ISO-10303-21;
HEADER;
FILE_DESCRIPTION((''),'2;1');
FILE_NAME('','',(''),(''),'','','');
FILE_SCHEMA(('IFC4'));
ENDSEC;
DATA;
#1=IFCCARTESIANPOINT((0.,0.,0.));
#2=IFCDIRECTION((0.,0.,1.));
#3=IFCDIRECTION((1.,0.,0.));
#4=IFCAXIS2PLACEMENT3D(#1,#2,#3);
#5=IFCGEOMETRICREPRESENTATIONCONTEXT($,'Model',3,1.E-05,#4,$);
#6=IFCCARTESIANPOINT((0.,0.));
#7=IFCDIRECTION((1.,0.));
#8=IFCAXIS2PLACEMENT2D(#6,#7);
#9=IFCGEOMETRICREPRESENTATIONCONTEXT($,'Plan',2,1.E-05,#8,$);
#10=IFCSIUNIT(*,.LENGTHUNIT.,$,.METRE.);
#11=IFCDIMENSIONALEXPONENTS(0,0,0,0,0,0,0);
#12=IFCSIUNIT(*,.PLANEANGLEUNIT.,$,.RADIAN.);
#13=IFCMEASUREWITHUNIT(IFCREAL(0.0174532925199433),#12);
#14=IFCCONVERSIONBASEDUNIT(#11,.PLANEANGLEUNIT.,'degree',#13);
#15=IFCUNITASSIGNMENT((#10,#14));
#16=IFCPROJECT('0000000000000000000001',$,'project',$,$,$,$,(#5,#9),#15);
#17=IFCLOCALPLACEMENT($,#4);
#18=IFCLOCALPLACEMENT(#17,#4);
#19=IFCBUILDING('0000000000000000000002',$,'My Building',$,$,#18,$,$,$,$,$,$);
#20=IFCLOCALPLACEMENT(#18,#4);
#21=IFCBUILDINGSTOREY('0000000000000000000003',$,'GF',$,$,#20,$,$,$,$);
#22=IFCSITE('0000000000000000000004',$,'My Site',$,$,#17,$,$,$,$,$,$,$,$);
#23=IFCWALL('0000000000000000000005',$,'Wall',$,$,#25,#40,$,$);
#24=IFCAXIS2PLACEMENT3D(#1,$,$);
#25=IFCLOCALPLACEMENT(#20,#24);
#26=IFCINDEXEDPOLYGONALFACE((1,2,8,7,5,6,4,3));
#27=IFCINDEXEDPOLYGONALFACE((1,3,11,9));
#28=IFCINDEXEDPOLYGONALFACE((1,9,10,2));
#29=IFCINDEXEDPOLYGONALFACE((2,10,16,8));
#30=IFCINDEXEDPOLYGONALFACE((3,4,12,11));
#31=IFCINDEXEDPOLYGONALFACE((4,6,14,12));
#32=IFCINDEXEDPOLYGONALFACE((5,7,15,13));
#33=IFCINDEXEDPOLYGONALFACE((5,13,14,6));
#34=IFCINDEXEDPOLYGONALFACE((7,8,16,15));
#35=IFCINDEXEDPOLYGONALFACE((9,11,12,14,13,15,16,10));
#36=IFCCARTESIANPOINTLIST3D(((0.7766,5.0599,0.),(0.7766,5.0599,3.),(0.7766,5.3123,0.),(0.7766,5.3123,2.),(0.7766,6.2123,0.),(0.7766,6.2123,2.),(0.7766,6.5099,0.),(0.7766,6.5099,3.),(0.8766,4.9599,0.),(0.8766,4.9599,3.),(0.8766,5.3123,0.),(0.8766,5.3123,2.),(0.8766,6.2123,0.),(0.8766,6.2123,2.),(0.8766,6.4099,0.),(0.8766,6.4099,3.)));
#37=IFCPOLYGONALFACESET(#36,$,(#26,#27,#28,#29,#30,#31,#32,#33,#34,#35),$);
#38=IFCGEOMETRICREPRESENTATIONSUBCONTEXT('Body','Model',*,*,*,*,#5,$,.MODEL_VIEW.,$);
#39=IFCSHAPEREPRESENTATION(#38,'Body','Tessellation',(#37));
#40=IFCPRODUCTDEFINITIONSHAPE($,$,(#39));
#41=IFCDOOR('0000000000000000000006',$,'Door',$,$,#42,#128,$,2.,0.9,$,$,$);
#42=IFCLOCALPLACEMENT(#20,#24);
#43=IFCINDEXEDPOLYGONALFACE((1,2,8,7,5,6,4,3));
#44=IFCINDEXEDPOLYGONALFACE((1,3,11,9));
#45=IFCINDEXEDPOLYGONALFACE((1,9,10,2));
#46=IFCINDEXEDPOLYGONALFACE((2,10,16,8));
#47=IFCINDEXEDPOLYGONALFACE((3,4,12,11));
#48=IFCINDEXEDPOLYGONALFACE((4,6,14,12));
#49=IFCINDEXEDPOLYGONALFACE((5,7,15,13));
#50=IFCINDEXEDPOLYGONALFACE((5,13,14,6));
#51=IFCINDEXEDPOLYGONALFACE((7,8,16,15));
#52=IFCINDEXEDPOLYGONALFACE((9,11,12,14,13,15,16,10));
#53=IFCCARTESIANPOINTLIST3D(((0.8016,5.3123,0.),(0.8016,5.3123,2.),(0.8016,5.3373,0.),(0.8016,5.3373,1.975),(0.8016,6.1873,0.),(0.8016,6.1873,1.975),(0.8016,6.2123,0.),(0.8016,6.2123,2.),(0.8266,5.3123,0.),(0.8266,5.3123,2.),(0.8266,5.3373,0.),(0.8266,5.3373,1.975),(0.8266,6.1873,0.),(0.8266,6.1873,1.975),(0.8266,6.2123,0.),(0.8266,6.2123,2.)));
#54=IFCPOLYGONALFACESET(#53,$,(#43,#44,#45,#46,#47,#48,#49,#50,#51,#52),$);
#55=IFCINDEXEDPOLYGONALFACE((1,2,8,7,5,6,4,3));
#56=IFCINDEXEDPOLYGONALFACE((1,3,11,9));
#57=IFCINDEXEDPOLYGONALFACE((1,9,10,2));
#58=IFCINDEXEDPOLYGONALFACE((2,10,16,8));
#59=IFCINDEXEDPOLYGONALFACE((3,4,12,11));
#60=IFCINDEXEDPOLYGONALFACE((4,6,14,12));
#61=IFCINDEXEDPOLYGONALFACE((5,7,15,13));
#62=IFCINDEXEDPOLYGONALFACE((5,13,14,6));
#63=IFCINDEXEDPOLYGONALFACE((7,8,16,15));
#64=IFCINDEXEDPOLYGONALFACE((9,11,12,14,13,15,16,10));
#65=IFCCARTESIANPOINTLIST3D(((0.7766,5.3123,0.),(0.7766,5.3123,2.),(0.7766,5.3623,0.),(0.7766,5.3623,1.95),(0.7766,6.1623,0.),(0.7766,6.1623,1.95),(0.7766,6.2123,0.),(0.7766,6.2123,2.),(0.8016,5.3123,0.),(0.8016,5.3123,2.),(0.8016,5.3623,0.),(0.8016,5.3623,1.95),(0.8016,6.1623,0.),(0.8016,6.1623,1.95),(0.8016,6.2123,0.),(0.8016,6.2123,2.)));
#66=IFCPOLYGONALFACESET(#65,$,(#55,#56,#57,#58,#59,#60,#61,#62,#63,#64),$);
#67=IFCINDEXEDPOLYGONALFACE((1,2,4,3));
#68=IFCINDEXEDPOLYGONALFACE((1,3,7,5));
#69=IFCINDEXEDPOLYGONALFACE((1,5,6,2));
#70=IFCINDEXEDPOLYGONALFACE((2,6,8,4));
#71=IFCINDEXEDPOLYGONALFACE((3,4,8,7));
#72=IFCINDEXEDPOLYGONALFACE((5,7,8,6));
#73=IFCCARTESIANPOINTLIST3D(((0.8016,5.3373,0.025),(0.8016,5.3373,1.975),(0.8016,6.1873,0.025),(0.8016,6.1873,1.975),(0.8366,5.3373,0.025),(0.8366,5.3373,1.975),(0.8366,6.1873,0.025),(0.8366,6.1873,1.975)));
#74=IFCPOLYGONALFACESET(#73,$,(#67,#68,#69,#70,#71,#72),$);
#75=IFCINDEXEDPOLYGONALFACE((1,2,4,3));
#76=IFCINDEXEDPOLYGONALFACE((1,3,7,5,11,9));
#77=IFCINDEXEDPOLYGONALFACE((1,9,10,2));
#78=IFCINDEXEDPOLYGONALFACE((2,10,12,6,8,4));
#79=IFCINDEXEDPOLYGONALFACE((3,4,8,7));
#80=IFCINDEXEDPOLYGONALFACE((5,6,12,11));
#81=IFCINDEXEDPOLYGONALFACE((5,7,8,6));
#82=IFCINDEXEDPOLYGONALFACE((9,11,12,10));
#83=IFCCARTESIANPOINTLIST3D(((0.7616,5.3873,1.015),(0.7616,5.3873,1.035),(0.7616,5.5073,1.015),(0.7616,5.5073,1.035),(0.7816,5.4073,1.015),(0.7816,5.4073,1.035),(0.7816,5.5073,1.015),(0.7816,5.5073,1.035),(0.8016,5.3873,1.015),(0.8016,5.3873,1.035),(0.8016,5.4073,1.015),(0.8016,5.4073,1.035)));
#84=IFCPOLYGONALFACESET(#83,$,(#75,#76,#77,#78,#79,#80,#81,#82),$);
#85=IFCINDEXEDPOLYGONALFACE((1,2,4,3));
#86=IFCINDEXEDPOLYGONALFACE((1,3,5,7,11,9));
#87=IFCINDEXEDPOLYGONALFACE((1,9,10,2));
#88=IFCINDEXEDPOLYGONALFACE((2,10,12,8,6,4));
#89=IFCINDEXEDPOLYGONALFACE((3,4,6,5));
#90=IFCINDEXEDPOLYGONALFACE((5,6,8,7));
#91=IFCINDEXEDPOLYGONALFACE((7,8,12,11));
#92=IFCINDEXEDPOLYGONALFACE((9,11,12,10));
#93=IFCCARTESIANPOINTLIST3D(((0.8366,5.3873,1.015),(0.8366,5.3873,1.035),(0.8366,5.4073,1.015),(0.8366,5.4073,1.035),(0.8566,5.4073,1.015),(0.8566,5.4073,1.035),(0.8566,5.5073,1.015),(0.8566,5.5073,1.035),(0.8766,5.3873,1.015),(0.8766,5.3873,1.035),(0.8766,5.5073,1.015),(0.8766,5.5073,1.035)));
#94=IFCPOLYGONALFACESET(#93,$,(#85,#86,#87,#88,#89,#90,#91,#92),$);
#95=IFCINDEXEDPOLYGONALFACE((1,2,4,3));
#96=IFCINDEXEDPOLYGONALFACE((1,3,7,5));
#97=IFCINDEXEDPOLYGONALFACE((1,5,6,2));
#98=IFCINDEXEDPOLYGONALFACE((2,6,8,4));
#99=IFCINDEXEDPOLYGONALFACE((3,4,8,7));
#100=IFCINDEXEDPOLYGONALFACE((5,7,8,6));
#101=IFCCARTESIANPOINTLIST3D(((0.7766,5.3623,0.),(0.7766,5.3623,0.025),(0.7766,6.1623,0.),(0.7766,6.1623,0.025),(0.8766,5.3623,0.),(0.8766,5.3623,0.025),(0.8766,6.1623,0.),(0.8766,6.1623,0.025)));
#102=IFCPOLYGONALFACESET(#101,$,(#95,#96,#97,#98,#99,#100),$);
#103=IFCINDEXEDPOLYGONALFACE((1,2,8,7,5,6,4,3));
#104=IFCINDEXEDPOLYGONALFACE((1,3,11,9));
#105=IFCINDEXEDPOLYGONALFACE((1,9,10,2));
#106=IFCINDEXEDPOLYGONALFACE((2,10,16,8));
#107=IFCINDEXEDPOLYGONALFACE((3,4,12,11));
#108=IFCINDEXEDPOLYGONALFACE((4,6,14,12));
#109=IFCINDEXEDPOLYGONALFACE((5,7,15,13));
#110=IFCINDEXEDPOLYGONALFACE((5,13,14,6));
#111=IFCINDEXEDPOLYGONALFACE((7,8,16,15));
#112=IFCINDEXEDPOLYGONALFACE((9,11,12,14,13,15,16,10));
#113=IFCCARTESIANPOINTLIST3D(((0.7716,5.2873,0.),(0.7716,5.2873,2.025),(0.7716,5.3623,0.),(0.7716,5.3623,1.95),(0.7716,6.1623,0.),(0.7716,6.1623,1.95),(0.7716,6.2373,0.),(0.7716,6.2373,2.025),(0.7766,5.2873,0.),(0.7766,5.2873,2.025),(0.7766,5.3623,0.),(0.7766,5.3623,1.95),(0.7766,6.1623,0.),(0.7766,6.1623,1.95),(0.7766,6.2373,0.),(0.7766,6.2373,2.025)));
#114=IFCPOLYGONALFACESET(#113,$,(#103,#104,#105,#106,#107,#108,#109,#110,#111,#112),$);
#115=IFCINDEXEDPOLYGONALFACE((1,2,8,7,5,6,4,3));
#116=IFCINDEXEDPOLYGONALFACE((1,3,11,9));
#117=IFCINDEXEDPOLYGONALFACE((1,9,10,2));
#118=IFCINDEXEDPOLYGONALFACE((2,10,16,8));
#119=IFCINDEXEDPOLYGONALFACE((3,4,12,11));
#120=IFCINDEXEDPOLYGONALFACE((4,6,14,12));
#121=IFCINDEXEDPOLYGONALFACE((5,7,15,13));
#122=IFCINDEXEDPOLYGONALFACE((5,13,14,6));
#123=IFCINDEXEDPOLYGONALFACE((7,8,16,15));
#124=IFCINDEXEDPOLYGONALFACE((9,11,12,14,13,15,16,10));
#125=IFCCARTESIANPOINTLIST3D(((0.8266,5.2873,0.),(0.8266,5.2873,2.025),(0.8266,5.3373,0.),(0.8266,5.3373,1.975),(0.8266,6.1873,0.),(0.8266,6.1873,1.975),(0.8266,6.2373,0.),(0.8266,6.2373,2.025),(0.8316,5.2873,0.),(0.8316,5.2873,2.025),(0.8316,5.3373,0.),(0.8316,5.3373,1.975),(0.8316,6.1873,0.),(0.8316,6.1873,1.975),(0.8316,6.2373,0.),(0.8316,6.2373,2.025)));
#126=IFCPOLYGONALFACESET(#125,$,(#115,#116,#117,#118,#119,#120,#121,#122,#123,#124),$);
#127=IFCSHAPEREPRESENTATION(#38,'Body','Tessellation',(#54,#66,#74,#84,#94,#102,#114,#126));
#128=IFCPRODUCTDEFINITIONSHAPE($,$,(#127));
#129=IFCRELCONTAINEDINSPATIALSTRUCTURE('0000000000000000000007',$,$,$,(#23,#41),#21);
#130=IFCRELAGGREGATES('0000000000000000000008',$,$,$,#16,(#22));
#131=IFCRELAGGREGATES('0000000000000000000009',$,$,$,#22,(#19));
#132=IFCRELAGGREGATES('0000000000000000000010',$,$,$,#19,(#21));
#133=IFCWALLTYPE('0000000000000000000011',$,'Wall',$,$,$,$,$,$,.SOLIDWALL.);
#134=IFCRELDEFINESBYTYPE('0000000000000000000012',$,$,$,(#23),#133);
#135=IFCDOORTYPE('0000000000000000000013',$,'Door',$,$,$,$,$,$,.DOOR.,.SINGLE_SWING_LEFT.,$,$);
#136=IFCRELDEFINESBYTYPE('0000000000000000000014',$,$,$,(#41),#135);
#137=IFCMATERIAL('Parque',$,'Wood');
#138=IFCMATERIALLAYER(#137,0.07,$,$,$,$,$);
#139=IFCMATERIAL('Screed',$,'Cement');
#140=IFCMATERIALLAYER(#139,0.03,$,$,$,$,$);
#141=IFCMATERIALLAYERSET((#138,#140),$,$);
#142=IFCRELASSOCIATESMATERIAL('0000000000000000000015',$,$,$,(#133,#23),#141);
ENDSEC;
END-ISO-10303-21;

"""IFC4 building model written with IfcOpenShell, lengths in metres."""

from ifc_helpers import new_model, entity, si_unit, converted_unit, frame, origin_with_axes, origin_2d_with_axis, place, context, subcontext, project, spatial, line, indexed_curve, outline, extrude, shape, source, transform, mapped, material, layer, layer_set, layer_usage, type_object, type_shapes, element, fill, save


model = new_model("IFC4")

# Units and contexts
model_context = context("Model", 3, precision=1e-05, world=origin_with_axes())
plan_context = context("Plan", 2, precision=1e-05, world=origin_2d_with_axis())
body_context_1 = subcontext(model_context, "Body", "Model", "MODEL_VIEW")
body_context_2 = subcontext(plan_context, "Body", "Plan", "PLAN_VIEW")
ifc_project = project(units=[si_unit("LENGTHUNIT", "METRE"), converted_unit("PLANEANGLEUNIT", "degree", entity("IfcReal", 0.0174532925199433), si_unit("PLANEANGLEUNIT", "RADIAN"), dimensions=[0, 0, 0, 0, 0, 0, 0])], contexts=[model_context, plan_context])

# Site, building, storey
site_placement = place(None, origin_with_axes())
site = spatial("IfcSite", under=ifc_project, at=site_placement, Name="My Site")
building_placement = place(site_placement, origin_with_axes())
building = spatial("IfcBuilding", under=site, at=building_placement, Name="My Building")
storey_placement = place(building_placement, origin_with_axes())
storey = spatial("IfcBuildingStorey", under=building, at=storey_placement, Name="GF")

# Shared definitions
ifc_material_1 = material(Name="Parque", Category="Wood")
ifc_layer_1 = layer(ifc_material_1, 0.07)
ifc_material_2 = material(Name="Screed", Category="Cement")
ifc_layer_2 = layer(ifc_material_2, 0.03)
ifc_layer_set_1 = layer_set([ifc_layer_1, ifc_layer_2])
wall_type = type_object("IfcWallType", Name="Wall", PredefinedType="SOLIDWALL", material=ifc_layer_set_1)

# Wall, opening, door
ifc_layer_usage_1 = layer_usage(ifc_layer_set_1, "AXIS2", "POSITIVE", 0.0)
wall_1_placement = place(storey_placement, frame((0.7766, 6.5099, 0.0), z_axis=(0.0, 0.0, 1.0), x_axis=(0.0, -1.0, 0.0)))
wall_1 = element("IfcWall", 1, at=wall_1_placement, inside=storey, type_object=wall_type, material=ifc_layer_usage_1, Name="Wall", context=body_context_1, shape_type="SweptSolid", body=[
    extrude(outline(indexed_curve([(0.0, 0.0), (0.1, 0.1), (1.55, 0.1), (1.45, 0.0)], segments=[line(1, 2, 3, 4, 1)])), origin_with_axes(), (0.0, 0.0, 1.0), 3.0),
])
shared_shape_1 = source(origin_with_axes(), body_context_1, "Body", "SweptSolid", [
    extrude(outline(indexed_curve([(0.0, 0.0), (0.9, 0.0), (0.9, 2.0), (0.0, 2.0)], segments=[line(1, 2, 3, 4, 1)])), frame((0.0, -0.6, 0.0), z_axis=(0.0, -1.0, 0.0), x_axis=(1.0, 0.0, 0.0)), (0.0, 0.0, -1.0), 1.2),
])
opening_1_placement = place(wall_1_placement, frame((0.2976, 0.0, 0.0), z_axis=(0.0, 0.0, 1.0), x_axis=(1.0, 0.0, 0.0)))
opening_1 = element("IfcOpeningElement", 2, at=opening_1_placement, cuts=wall_1, PredefinedType="OPENING", context=body_context_1, shape_type="MappedRepresentation", body=[
    mapped(shared_shape_1, transform((0.0, 0.0, 0.0), x_axis=(1.0, 0.0, 0.0), y_axis=(0.0, 1.0, 0.0), z_axis=(0.0, 0.0, 1.0), scale=1.0)),
])
door_type = type_object("IfcDoorType", Name="Door", OperationType="SINGLE_SWING_LEFT", PredefinedType="DOOR")
shared_shape_2 = source(origin_with_axes(), body_context_1, "Body", "SweptSolid", [
    extrude(outline(indexed_curve([(0.0, 0.0), (0.0, 2.0), (0.9, 2.0), (0.9, 0.0), (0.875, 0.0), (0.875, 1.975), (0.025, 1.975), (0.025, 0.0)], segments=[line(1, 2, 3, 4, 5, 6, 7, 8, 1)])), frame((0.0, 0.025, 0.0), z_axis=(0.0, -1.0, 0.0), x_axis=(1.0, 0.0, 0.0)), (0.0, 0.0, -1.0), 0.025),
    extrude(outline(indexed_curve([(0.0, 0.0), (0.0, 2.0), (0.9, 2.0), (0.9, 0.0), (0.85, 0.0), (0.85, 1.95), (0.05, 1.95), (0.05, 0.0)], segments=[line(1, 2, 3, 4, 5, 6, 7, 8, 1)])), frame((0.0, 0.0, 0.0), z_axis=(0.0, -1.0, 0.0), x_axis=(1.0, 0.0, 0.0)), (0.0, 0.0, -1.0), 0.025),
    extrude(outline(indexed_curve([(0.0, 0.0), (0.85, 0.0), (0.85, 0.035), (0.0, 0.035)], segments=[line(1, 2, 3, 4, 1)])), frame((0.025, 0.025, 0.025), z_axis=(0.0, 0.0, 1.0), x_axis=(1.0, 0.0, 0.0)), (0.0, 0.0, 1.0), 1.95),
    extrude(outline(indexed_curve([(0.0, 0.0), (0.0, -0.04), (-0.12, -0.04), (-0.12, -0.02), (-0.02, -0.02), (-0.02, 0.0)], segments=[line(1, 2, 3, 4, 5, 6, 1)])), frame((0.825, 0.025, 1.015), z_axis=(0.0, 0.0, 1.0), x_axis=(1.0, 0.0, 0.0)), (0.0, 0.0, 1.0), 0.02),
    extrude(outline(indexed_curve([(0.0, 0.0), (0.0, 0.04), (-0.12, 0.04), (-0.12, 0.02), (-0.02, 0.02), (-0.02, 0.0)], segments=[line(1, 2, 3, 4, 5, 6, 1)])), frame((0.825, 0.06, 1.015), z_axis=(0.0, 0.0, 1.0), x_axis=(1.0, 0.0, 0.0)), (0.0, 0.0, 1.0), 0.02),
    extrude(outline(indexed_curve([(0.0, 0.0), (0.8, 0.0), (0.8, 0.1), (0.0, 0.1)], segments=[line(1, 2, 3, 4, 1)])), frame((0.05, 0.0, 0.0), z_axis=(0.0, 0.0, 1.0), x_axis=(1.0, 0.0, 0.0)), (0.0, 0.0, 1.0), 0.025),
    extrude(outline(indexed_curve([(0.0, 0.0), (0.0, 2.025), (0.95, 2.025), (0.95, 0.0), (0.875, 0.0), (0.875, 1.95), (0.075, 1.95), (0.075, 0.0)], segments=[line(1, 2, 3, 4, 5, 6, 7, 8, 1)])), frame((-0.025, -0.005, 0.0), z_axis=(0.0, -1.0, 0.0), x_axis=(1.0, 0.0, 0.0)), (0.0, 0.0, -1.0), 0.005),
    extrude(outline(indexed_curve([(0.0, 0.0), (0.0, 2.025), (0.95, 2.025), (0.95, 0.0), (0.9, 0.0), (0.9, 1.975), (0.05, 1.975), (0.05, 0.0)], segments=[line(1, 2, 3, 4, 5, 6, 7, 8, 1)])), frame((-0.025, 0.05, 0.0), z_axis=(0.0, -1.0, 0.0), x_axis=(1.0, 0.0, 0.0)), (0.0, 0.0, -1.0), 0.005),
])
shared_shape_3 = source(origin_with_axes(), body_context_2, "Body", "Curve2D", [
    entity("IfcIndexedPolyCurve", entity("IfcCartesianPointList2D", [[0.0, 0.0], [0.0, 0.05], [0.025, 0.05], [0.025, 0.025], [0.05, 0.025], [0.05, 0.0]]), [entity("IfcLineIndex", [1, 2, 3, 4, 5, 6, 1])]),
    entity("IfcIndexedPolyCurve", entity("IfcCartesianPointList2D", [[0.9, 0.0], [0.9, 0.05], [0.875, 0.05], [0.875, 0.025], [0.85, 0.025], [0.85, 0.0]]), [entity("IfcLineIndex", [1, 2, 3, 4, 5, 6, 1])]),
    entity("IfcTrimmedCurve", entity("IfcEllipse", entity("IfcAxis2Placement2D", entity("IfcCartesianPoint", [0.06, 0.05]), entity("IfcDirection", [1.0, 0.0])), 0.815, 0.85), [entity("IfcCartesianPoint", [0.875, 0.05])], [entity("IfcCartesianPoint", [0.06, 0.9])], True, "CARTESIAN"),
    entity("IfcIndexedPolyCurve", entity("IfcCartesianPointList2D", [[0.025, 0.05], [0.06, 0.05], [0.06, 0.9], [0.025, 0.9]]), [entity("IfcLineIndex", [1, 2, 3, 4, 1])]),
])
type_shapes(door_type, [shared_shape_2, shared_shape_3])
door_1_placement = place(opening_1_placement, frame((0.0, 0.0, 0.0), z_axis=(0.0, 0.0, 1.0), x_axis=(1.0, 0.0, 0.0)))
door_1 = element("IfcDoor", 3, at=door_1_placement, inside=storey, type_object=door_type, Name="Door", OverallHeight=2.0, OverallWidth=0.9, shapes=[
    shape(body_context_1, "Body", "MappedRepresentation", [mapped(shared_shape_2, transform((0.0, 0.0, 0.0), x_axis=(1.0, 0.0, 0.0), y_axis=(0.0, 1.0, 0.0), z_axis=(0.0, 0.0, 1.0), scale=1.0))]),
    shape(body_context_2, "Body", "MappedRepresentation", [mapped(shared_shape_3, transform((0.0, 0.0, 0.0), x_axis=(1.0, 0.0, 0.0), y_axis=(0.0, 1.0, 0.0), z_axis=(0.0, 0.0, 1.0), scale=1.0))]),
])
fill(opening_1, door_1)

save(model, "model.ifc")
